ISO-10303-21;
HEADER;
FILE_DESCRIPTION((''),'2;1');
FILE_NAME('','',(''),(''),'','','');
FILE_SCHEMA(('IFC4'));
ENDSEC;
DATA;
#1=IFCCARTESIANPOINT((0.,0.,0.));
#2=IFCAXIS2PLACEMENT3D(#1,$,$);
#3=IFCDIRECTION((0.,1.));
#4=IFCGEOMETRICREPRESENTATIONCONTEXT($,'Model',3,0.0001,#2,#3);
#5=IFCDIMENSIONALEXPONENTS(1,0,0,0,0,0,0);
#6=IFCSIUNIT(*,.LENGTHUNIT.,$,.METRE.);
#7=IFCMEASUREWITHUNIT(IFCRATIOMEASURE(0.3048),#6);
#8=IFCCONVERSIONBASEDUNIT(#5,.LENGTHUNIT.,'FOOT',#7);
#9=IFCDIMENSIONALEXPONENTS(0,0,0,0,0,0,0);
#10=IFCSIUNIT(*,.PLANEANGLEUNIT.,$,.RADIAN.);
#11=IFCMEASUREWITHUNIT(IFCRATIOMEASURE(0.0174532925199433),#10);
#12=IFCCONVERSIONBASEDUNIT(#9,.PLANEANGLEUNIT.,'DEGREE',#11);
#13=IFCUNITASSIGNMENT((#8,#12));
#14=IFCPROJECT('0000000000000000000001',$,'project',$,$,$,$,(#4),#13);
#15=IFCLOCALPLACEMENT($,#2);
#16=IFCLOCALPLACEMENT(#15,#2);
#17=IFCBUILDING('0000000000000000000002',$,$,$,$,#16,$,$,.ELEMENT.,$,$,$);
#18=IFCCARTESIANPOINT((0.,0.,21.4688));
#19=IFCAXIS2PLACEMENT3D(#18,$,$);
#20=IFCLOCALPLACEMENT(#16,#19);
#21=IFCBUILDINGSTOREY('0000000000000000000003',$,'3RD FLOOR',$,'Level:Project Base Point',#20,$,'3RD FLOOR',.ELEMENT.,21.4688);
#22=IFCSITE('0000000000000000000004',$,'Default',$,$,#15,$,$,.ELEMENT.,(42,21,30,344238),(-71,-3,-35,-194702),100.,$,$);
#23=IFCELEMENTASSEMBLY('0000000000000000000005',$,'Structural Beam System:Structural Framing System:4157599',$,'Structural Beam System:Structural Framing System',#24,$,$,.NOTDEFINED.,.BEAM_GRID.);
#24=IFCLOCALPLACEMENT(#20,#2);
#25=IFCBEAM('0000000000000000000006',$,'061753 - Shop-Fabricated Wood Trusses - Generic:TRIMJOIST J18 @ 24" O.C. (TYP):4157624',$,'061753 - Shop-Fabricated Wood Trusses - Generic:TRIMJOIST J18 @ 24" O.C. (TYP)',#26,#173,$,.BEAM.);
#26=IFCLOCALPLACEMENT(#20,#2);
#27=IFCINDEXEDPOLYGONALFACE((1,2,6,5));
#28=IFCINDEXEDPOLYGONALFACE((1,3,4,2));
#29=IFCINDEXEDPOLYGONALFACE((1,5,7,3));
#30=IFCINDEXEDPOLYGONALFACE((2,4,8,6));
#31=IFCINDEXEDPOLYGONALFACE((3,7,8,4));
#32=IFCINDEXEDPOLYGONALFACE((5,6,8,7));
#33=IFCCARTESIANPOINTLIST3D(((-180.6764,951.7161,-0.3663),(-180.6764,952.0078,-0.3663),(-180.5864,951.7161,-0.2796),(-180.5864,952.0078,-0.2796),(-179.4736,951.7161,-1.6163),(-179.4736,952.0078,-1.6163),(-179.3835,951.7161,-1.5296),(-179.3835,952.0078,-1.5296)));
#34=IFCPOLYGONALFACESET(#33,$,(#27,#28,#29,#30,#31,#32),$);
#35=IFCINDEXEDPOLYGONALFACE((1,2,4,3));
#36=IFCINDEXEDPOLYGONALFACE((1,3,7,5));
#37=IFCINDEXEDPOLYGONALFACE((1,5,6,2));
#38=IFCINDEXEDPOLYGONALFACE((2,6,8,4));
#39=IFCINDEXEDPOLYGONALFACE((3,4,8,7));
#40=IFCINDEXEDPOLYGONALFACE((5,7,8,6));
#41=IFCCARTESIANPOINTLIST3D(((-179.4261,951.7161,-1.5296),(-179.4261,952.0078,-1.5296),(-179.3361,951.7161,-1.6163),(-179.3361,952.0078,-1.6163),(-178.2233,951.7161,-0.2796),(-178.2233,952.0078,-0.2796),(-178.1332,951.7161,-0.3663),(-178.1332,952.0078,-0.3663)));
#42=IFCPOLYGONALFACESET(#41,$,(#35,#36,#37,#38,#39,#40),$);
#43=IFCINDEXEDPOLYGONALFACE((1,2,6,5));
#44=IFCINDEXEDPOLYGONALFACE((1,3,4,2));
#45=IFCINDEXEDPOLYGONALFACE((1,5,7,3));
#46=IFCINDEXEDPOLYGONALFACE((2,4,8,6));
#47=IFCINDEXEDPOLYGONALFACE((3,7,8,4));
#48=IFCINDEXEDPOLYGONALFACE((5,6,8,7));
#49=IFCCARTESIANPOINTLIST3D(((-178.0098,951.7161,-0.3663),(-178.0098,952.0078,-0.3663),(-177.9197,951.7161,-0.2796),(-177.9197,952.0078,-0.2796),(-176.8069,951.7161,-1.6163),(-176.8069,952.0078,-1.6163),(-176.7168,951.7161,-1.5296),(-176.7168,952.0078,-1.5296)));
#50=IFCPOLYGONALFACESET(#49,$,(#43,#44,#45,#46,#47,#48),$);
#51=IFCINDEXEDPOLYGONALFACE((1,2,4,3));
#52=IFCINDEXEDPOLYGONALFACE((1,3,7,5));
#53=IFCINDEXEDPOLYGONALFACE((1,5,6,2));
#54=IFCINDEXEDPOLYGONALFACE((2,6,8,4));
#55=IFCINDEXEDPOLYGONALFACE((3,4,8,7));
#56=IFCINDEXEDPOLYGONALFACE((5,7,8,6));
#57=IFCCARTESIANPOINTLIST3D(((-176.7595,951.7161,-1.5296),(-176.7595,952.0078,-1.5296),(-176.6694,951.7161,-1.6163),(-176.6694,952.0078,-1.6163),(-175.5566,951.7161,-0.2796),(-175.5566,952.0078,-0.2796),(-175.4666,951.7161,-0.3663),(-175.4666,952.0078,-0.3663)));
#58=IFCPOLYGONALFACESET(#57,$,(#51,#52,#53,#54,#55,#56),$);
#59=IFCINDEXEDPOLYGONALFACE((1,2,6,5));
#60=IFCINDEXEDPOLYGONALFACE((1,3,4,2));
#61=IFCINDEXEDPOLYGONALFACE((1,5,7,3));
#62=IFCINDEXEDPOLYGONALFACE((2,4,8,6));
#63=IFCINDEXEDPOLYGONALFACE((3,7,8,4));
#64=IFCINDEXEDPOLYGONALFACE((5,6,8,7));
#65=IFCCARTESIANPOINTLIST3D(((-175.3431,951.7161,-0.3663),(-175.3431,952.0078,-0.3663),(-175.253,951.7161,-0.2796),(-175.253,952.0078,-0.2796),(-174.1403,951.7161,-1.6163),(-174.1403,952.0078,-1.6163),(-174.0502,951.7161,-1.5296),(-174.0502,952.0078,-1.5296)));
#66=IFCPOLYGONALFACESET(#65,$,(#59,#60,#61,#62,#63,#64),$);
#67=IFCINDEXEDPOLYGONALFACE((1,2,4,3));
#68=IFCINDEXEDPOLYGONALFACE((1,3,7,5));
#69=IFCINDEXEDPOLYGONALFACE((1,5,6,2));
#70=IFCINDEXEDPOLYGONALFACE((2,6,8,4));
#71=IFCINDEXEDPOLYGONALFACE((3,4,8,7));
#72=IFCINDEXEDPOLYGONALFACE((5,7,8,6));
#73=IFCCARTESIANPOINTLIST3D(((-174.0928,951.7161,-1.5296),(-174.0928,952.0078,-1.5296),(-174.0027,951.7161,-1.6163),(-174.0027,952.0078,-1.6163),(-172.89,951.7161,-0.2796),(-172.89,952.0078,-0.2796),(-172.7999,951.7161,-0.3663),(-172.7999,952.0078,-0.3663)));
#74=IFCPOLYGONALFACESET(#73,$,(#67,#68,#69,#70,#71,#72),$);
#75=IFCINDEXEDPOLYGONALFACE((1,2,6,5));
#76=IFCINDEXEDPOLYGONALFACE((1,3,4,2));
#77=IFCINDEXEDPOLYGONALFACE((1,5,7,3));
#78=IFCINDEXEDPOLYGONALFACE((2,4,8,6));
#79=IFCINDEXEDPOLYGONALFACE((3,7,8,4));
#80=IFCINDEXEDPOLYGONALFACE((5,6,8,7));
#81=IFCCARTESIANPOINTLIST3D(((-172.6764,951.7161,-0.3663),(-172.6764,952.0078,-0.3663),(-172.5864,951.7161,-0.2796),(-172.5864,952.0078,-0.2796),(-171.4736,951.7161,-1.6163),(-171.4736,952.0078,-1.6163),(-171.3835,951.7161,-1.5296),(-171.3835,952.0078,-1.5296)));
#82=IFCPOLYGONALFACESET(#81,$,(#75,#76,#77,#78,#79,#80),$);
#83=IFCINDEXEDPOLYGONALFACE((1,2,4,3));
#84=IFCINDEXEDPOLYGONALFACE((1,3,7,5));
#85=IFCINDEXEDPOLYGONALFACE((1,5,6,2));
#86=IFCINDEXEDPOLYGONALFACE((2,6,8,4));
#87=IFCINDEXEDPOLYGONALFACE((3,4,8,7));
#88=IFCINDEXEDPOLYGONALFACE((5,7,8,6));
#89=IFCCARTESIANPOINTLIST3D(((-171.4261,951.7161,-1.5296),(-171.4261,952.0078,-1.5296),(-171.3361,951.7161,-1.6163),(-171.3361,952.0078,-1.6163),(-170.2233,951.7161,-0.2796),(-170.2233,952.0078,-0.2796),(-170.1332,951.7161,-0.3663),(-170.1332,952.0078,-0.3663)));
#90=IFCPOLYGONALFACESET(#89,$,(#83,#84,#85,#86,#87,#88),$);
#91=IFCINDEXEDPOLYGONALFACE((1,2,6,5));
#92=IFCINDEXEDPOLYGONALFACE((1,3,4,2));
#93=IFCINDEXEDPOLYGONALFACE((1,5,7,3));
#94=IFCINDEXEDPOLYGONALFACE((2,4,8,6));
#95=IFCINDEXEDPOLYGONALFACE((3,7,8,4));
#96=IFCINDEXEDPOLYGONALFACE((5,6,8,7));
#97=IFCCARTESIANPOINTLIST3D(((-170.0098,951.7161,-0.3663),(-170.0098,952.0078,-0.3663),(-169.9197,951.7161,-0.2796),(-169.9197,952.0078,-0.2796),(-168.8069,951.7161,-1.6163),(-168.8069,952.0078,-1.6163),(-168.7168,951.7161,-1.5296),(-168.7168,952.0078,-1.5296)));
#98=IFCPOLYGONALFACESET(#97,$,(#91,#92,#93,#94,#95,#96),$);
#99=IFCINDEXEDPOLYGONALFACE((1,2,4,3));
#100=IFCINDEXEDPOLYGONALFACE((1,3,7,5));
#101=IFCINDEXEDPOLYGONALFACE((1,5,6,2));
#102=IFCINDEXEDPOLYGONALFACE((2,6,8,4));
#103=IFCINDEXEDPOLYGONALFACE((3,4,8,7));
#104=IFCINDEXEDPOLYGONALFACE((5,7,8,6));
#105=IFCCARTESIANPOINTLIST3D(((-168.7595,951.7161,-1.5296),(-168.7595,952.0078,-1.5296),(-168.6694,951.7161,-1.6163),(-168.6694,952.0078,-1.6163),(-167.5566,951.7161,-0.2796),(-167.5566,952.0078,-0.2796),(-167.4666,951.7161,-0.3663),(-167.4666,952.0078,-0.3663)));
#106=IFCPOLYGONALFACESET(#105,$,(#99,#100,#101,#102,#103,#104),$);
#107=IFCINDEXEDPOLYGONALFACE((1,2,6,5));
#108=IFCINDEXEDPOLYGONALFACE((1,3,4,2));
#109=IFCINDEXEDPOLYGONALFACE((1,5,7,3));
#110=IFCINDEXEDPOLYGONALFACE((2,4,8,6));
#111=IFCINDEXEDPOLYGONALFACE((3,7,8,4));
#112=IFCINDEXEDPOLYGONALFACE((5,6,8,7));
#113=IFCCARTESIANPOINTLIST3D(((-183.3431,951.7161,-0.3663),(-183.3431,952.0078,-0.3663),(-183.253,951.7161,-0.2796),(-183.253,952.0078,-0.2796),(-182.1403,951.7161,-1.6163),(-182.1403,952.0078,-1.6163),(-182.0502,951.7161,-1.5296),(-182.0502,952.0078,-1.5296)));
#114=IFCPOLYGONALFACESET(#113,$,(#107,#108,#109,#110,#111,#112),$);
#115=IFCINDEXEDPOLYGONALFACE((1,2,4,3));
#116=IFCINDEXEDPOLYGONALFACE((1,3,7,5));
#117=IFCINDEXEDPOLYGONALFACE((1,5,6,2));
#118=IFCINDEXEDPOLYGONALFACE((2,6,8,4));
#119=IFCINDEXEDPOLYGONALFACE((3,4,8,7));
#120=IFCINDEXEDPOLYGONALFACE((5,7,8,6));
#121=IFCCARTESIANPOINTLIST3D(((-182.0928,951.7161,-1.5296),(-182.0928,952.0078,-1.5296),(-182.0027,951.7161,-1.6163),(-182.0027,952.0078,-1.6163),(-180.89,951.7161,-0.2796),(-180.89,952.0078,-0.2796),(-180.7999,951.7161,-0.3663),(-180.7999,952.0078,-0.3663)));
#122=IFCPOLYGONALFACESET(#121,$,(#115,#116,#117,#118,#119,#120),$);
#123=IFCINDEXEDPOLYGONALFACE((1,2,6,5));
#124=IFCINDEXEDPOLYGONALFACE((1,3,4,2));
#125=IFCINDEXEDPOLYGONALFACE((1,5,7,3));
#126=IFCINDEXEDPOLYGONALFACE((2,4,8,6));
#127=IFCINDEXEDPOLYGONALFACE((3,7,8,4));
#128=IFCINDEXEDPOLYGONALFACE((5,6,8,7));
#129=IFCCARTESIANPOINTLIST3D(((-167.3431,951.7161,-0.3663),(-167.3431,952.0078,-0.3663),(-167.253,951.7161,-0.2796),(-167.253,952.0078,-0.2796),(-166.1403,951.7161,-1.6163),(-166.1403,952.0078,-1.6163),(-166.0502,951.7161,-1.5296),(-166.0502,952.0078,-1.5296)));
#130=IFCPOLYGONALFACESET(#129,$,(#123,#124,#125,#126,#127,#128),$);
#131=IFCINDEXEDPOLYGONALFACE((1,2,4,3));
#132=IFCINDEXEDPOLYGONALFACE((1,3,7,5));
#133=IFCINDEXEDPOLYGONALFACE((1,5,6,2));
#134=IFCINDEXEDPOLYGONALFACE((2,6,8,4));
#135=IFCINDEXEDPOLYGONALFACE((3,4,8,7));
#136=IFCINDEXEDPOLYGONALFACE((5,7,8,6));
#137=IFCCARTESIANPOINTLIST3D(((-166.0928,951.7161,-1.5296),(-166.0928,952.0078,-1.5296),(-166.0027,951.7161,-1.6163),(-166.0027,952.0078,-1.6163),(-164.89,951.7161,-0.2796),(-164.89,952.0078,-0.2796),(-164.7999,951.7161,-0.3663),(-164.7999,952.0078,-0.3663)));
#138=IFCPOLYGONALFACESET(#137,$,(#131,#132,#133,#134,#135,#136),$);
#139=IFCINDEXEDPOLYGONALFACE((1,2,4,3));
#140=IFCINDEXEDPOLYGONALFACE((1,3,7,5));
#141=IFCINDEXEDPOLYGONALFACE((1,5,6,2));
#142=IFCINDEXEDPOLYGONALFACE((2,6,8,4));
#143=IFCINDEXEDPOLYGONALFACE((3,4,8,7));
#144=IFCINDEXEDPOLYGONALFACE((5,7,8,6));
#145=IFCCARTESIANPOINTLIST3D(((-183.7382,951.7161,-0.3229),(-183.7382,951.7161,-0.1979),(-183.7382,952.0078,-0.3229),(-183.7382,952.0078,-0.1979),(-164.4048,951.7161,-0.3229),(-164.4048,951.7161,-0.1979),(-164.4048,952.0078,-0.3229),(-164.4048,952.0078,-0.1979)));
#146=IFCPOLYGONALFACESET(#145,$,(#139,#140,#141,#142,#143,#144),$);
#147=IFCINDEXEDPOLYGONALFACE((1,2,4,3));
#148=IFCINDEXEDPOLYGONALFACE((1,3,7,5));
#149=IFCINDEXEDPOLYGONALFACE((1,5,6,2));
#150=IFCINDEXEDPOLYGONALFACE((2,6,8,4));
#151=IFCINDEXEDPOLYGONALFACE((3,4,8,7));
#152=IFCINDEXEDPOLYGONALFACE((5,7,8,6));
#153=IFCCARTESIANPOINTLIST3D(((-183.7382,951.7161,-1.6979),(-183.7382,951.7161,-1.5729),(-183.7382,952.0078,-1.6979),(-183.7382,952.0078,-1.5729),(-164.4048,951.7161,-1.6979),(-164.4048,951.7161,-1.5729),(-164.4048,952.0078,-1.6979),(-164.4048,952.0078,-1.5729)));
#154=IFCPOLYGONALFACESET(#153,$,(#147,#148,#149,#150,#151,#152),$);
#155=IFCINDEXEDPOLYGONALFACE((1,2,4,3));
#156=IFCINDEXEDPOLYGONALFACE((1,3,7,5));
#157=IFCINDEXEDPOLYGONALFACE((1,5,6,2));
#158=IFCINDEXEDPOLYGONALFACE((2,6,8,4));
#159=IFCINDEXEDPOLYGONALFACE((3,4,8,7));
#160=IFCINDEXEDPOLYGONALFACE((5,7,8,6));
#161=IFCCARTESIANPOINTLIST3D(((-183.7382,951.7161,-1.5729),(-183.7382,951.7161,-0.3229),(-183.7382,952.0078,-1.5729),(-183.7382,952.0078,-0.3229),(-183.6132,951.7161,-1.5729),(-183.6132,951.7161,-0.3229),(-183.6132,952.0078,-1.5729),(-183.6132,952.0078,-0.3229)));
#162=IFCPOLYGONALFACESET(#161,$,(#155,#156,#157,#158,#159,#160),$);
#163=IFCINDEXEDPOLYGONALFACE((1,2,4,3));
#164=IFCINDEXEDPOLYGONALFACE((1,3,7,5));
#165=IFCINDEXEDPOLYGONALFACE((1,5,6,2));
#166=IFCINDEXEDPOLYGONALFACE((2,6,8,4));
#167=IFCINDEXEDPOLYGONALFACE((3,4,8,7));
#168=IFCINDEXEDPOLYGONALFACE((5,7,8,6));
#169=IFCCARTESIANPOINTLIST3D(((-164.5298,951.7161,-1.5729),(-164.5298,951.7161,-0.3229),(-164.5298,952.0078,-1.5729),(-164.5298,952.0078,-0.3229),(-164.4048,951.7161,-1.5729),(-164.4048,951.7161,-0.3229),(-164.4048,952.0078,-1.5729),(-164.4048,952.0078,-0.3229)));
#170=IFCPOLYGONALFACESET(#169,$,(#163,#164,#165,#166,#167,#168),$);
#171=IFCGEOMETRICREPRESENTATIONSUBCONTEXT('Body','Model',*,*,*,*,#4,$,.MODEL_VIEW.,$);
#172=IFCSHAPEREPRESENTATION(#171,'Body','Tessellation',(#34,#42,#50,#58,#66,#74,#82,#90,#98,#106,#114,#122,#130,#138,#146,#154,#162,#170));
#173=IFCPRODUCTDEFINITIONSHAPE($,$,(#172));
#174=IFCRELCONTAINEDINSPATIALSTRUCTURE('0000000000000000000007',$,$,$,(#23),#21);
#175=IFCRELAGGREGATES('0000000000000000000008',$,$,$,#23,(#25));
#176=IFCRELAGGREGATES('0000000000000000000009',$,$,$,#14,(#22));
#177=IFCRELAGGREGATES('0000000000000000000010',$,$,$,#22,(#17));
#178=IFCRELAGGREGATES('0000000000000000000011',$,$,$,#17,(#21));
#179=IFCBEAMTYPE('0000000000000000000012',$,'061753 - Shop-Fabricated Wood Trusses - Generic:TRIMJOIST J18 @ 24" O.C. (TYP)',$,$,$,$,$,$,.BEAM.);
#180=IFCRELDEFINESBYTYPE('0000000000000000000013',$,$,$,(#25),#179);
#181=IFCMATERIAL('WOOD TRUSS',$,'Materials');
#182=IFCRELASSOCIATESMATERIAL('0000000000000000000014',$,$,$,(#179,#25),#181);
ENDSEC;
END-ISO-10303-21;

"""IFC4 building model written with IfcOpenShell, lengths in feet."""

from ifc_helpers import new_model, entity, si_unit, converted_unit, direction, frame, frame_2d, origin, origin_2d_with_axis, place, context, subcontext, project, spatial, rectangle, extrude, source, transform, mapped, material, material_profile, profile_set, profile_usage, type_object, type_shapes, element, aggregate, save


model = new_model("IFC4")

# Units and contexts
model_context = context("Model", 3, precision=0.0001, world=origin(), true_north=direction((0.0, 1.0)))
body_context = subcontext(model_context, "Body", "Model", "MODEL_VIEW")
ifc_project = project(units=[converted_unit("LENGTHUNIT", "FOOT", entity("IfcRatioMeasure", 0.3048), si_unit("LENGTHUNIT", "METRE"), dimensions=[1, 0, 0, 0, 0, 0, 0]), converted_unit("PLANEANGLEUNIT", "DEGREE", entity("IfcRatioMeasure", 0.0174532925199433), si_unit("PLANEANGLEUNIT", "RADIAN"), dimensions=[0, 0, 0, 0, 0, 0, 0])], contexts=[model_context])

# Site, building, storey
site_placement = place(None, origin())
site = spatial("IfcSite", under=ifc_project, at=site_placement, Name="Default", CompositionType="ELEMENT", RefLatitude=(42, 21, 30, 344238), RefLongitude=(-71, -3, -35, -194702), RefElevation=100.0)
building_placement = place(site_placement, origin())
building = spatial("IfcBuilding", under=site, at=building_placement, CompositionType="ELEMENT")
storey_placement = place(building_placement, frame((0.0, 0.0, 21.4688)))
storey = spatial("IfcBuildingStorey", under=building, at=storey_placement, Name="3RD FLOOR", ObjectType="Level:Project Base Point", LongName="3RD FLOOR", CompositionType="ELEMENT", Elevation=21.4688)

# Element assembly, beam
ifc_material = material(Name="WOOD TRUSS", Category="Materials")
ifc_material_profile_1 = material_profile(ifc_material, rectangle(XDim=1.7347, YDim=0.125, at=frame_2d((0.0, 0.0), x_axis=(1.0, 0.0))), Name="TRIMJOIST J18 @ 24\" O.C. (TYP)")
ifc_material_profile_2 = material_profile(ifc_material, rectangle(XDim=1.7347, YDim=0.125, at=frame_2d((0.0, 0.0), x_axis=(1.0, 0.0))), Name="TRIMJOIST J18 @ 24\" O.C. (TYP)")
ifc_material_profile_3 = material_profile(ifc_material, rectangle(XDim=1.7347, YDim=0.125, at=frame_2d((0.0, 0.0), x_axis=(1.0, 0.0))), Name="TRIMJOIST J18 @ 24\" O.C. (TYP)")
ifc_material_profile_4 = material_profile(ifc_material, rectangle(XDim=1.7347, YDim=0.125, at=frame_2d((0.0, 0.0), x_axis=(1.0, 0.0))), Name="TRIMJOIST J18 @ 24\" O.C. (TYP)")
ifc_material_profile_5 = material_profile(ifc_material, rectangle(XDim=1.7347, YDim=0.125, at=frame_2d((0.0, 0.0), x_axis=(1.0, 0.0))), Name="TRIMJOIST J18 @ 24\" O.C. (TYP)")
ifc_material_profile_6 = material_profile(ifc_material, rectangle(XDim=1.7347, YDim=0.125, at=frame_2d((0.0, 0.0), x_axis=(1.0, 0.0))), Name="TRIMJOIST J18 @ 24\" O.C. (TYP)")
ifc_material_profile_7 = material_profile(ifc_material, rectangle(XDim=1.7347, YDim=0.125, at=frame_2d((0.0, 0.0), x_axis=(1.0, 0.0))), Name="TRIMJOIST J18 @ 24\" O.C. (TYP)")
ifc_material_profile_8 = material_profile(ifc_material, rectangle(XDim=1.7347, YDim=0.125, at=frame_2d((0.0, 0.0), x_axis=(1.0, 0.0))), Name="TRIMJOIST J18 @ 24\" O.C. (TYP)")
ifc_material_profile_9 = material_profile(ifc_material, rectangle(XDim=1.7347, YDim=0.125, at=frame_2d((0.0, 0.0), x_axis=(1.0, 0.0))), Name="TRIMJOIST J18 @ 24\" O.C. (TYP)")
ifc_material_profile_10 = material_profile(ifc_material, rectangle(XDim=1.7347, YDim=0.125, at=origin_2d_with_axis()), Name="TRIMJOIST J18 @ 24\" O.C. (TYP)")
ifc_material_profile_11 = material_profile(ifc_material, rectangle(XDim=0.125, YDim=0.2917, at=origin_2d_with_axis()), Name="TRIMJOIST J18 @ 24\" O.C. (TYP)")
ifc_material_profile_12 = material_profile(ifc_material, rectangle(XDim=0.125, YDim=0.2917, at=origin_2d_with_axis()), Name="TRIMJOIST J18 @ 24\" O.C. (TYP)")
ifc_material_profile_13 = material_profile(ifc_material, rectangle(XDim=1.25, YDim=0.2917, at=origin_2d_with_axis()), Name="TRIMJOIST J18 @ 24\" O.C. (TYP)")
ifc_material_profile_14 = material_profile(ifc_material, rectangle(XDim=1.25, YDim=0.2917, at=origin_2d_with_axis()), Name="TRIMJOIST J18 @ 24\" O.C. (TYP)")
ifc_profile_set = profile_set([ifc_material_profile_1, ifc_material_profile_2, ifc_material_profile_3, ifc_material_profile_4, ifc_material_profile_5, ifc_material_profile_6, ifc_material_profile_7, ifc_material_profile_8, ifc_material_profile_9, ifc_material_profile_10, ifc_material_profile_11, ifc_material_profile_12, ifc_material_profile_13, ifc_material_profile_14], Name="TRIMJOIST J18 @ 24\" O.C. (TYP)")
assembly_1_placement = place(storey_placement, origin())
assembly_1 = element("IfcElementAssembly", 1, at=assembly_1_placement, inside=storey, Name="Structural Beam System:Structural Framing System:4157599", ObjectType="Structural Beam System:Structural Framing System", AssemblyPlace="NOTDEFINED", PredefinedType="BEAM_GRID")
ifc_profile_usage_1 = profile_usage(ifc_profile_set, cardinal=8)
beam_type_1 = type_object("IfcBeamType", Name="061753 - Shop-Fabricated Wood Trusses - Generic:TRIMJOIST J18 @ 24\" O.C. (TYP)", PredefinedType="BEAM", material=ifc_profile_set)
shared_shape_1 = source(origin(), body_context, "Body", "SweptSolid", [
    extrude(rectangle(XDim=1.7347, YDim=0.125, at=frame_2d((0.0, 0.0), x_axis=(1.0, 0.0))), frame((5.9585, -0.1458, 0.0), z_axis=(0.0, 1.0, 0.0), x_axis=(0.693383, 0.0, 0.720569)), (0.0, 0.0, 1.0), 0.2917),
    extrude(rectangle(XDim=1.7347, YDim=0.125, at=origin_2d_with_axis()), frame((4.7082, -0.1458, 0.0), z_axis=(0.0, 1.0, 0.0), x_axis=(0.693383, 0.0, -0.720569)), (0.0, 0.0, 1.0), 0.2917),
    extrude(rectangle(XDim=1.7347, YDim=0.125, at=frame_2d((0.0, 0.0), x_axis=(1.0, 0.0))), frame((3.2918, -0.1458, 0.0), z_axis=(0.0, 1.0, 0.0), x_axis=(0.693383, 0.0, 0.720569)), (0.0, 0.0, 1.0), 0.2917),
    extrude(rectangle(XDim=1.7347, YDim=0.125, at=frame_2d((0.0, 0.0), x_axis=(1.0, 0.0))), frame((2.0415, -0.1458, 0.0), z_axis=(0.0, 1.0, 0.0), x_axis=(0.693383, 0.0, -0.720569)), (0.0, 0.0, 1.0), 0.2917),
    extrude(rectangle(XDim=1.7347, YDim=0.125, at=frame_2d((0.0, 0.0), x_axis=(1.0, 0.0))), frame((0.6251, -0.1458, 0.0), z_axis=(0.0, 1.0, 0.0), x_axis=(0.693383, 0.0, 0.720569)), (0.0, 0.0, 1.0), 0.2917),
    extrude(rectangle(XDim=1.7347, YDim=0.125, at=frame_2d((0.0, 0.0), x_axis=(1.0, 0.0))), frame((-0.6251, -0.1458, 0.0), z_axis=(0.0, 1.0, 0.0), x_axis=(0.693383, 0.0, -0.720569)), (0.0, 0.0, 1.0), 0.2917),
    extrude(rectangle(XDim=1.7347, YDim=0.125, at=frame_2d((0.0, 0.0), x_axis=(1.0, 0.0))), frame((-2.0415, -0.1458, 0.0), z_axis=(0.0, 1.0, 0.0), x_axis=(0.693383, 0.0, 0.720569)), (0.0, 0.0, 1.0), 0.2917),
    extrude(rectangle(XDim=1.7347, YDim=0.125, at=origin_2d_with_axis()), frame((-3.2918, -0.1458, 0.0), z_axis=(0.0, 1.0, 0.0), x_axis=(0.693383, 0.0, -0.720569)), (0.0, 0.0, 1.0), 0.2917),
    extrude(rectangle(XDim=1.7347, YDim=0.125, at=frame_2d((0.0, 0.0), x_axis=(1.0, 0.0))), frame((-4.7082, -0.1458, 0.0), z_axis=(0.0, 1.0, 0.0), x_axis=(0.693383, 0.0, 0.720569)), (0.0, 0.0, 1.0), 0.2917),
    extrude(rectangle(XDim=1.7347, YDim=0.125, at=frame_2d((0.0, 0.0), x_axis=(1.0, 0.0))), frame((-5.9585, -0.1458, 0.0), z_axis=(0.0, 1.0, 0.0), x_axis=(0.693383, 0.0, -0.720569)), (0.0, 0.0, 1.0), 0.2917),
    extrude(rectangle(XDim=1.7347, YDim=0.125, at=frame_2d((0.0, 0.0), x_axis=(1.0, 0.0))), frame((8.6251, -0.1458, 0.0), z_axis=(0.0, 1.0, 0.0), x_axis=(0.693383, 0.0, 0.720569)), (0.0, 0.0, 1.0), 0.2917),
    extrude(rectangle(XDim=1.7347, YDim=0.125, at=origin_2d_with_axis()), frame((7.3749, -0.1458, 0.0), z_axis=(0.0, 1.0, 0.0), x_axis=(0.693383, 0.0, -0.720569)), (0.0, 0.0, 1.0), 0.2917),
    extrude(rectangle(XDim=1.7347, YDim=0.125, at=frame_2d((0.0, 0.0), x_axis=(1.0, 0.0))), frame((-7.3749, -0.1458, 0.0), z_axis=(0.0, 1.0, 0.0), x_axis=(0.693383, 0.0, 0.720569)), (0.0, 0.0, 1.0), 0.2917),
    extrude(rectangle(XDim=1.7347, YDim=0.125, at=origin_2d_with_axis()), frame((-8.6251, -0.1458, 0.0), z_axis=(0.0, 1.0, 0.0), x_axis=(0.693383, 0.0, -0.720569)), (0.0, 0.0, 1.0), 0.2917),
    extrude(rectangle(XDim=0.125, YDim=0.2917, at=origin_2d_with_axis()), frame((-9.6667, 0.0, 0.6875), z_axis=(1.0, 0.0, 0.0), x_axis=(0.0, 0.0, -1.0)), (0.0, 0.0, 1.0), 19.3333),
    extrude(rectangle(XDim=0.125, YDim=0.2917, at=origin_2d_with_axis()), frame((-9.6667, 0.0, -0.6875), z_axis=(1.0, 0.0, 0.0), x_axis=(0.0, 0.0, -1.0)), (0.0, 0.0, 1.0), 19.3333),
    extrude(rectangle(XDim=1.25, YDim=0.2917, at=origin_2d_with_axis()), frame((9.5417, 0.0, 0.0), z_axis=(1.0, 0.0, 0.0), x_axis=(0.0, 0.0, -1.0)), (0.0, 0.0, 1.0), 0.125),
    extrude(rectangle(XDim=1.25, YDim=0.2917, at=origin_2d_with_axis()), frame((-9.6667, 0.0, 0.0), z_axis=(1.0, 0.0, 0.0), x_axis=(0.0, 0.0, -1.0)), (0.0, 0.0, 1.0), 0.125),
])
type_shapes(beam_type_1, [shared_shape_1])
beam_1_placement = place(assembly_1_placement, frame((-174.0715, 951.8619, -0.9479), z_axis=(0.0, 0.0, 1.0), x_axis=(-1.0, 0.0, 0.0)))
beam_1 = element("IfcBeam", 2, at=beam_1_placement, type_object=beam_type_1, material=ifc_profile_usage_1, Name="061753 - Shop-Fabricated Wood Trusses - Generic:TRIMJOIST J18 @ 24\" O.C. (TYP):4157624", ObjectType="061753 - Shop-Fabricated Wood Trusses - Generic:TRIMJOIST J18 @ 24\" O.C. (TYP)", PredefinedType="BEAM", context=body_context, shape_type="MappedRepresentation", body=[
    mapped(shared_shape_1, transform((0.0, 0.0, 0.0), scale=1.0)),
])
aggregate(assembly_1, [beam_1])

save(model, "model.ifc")
